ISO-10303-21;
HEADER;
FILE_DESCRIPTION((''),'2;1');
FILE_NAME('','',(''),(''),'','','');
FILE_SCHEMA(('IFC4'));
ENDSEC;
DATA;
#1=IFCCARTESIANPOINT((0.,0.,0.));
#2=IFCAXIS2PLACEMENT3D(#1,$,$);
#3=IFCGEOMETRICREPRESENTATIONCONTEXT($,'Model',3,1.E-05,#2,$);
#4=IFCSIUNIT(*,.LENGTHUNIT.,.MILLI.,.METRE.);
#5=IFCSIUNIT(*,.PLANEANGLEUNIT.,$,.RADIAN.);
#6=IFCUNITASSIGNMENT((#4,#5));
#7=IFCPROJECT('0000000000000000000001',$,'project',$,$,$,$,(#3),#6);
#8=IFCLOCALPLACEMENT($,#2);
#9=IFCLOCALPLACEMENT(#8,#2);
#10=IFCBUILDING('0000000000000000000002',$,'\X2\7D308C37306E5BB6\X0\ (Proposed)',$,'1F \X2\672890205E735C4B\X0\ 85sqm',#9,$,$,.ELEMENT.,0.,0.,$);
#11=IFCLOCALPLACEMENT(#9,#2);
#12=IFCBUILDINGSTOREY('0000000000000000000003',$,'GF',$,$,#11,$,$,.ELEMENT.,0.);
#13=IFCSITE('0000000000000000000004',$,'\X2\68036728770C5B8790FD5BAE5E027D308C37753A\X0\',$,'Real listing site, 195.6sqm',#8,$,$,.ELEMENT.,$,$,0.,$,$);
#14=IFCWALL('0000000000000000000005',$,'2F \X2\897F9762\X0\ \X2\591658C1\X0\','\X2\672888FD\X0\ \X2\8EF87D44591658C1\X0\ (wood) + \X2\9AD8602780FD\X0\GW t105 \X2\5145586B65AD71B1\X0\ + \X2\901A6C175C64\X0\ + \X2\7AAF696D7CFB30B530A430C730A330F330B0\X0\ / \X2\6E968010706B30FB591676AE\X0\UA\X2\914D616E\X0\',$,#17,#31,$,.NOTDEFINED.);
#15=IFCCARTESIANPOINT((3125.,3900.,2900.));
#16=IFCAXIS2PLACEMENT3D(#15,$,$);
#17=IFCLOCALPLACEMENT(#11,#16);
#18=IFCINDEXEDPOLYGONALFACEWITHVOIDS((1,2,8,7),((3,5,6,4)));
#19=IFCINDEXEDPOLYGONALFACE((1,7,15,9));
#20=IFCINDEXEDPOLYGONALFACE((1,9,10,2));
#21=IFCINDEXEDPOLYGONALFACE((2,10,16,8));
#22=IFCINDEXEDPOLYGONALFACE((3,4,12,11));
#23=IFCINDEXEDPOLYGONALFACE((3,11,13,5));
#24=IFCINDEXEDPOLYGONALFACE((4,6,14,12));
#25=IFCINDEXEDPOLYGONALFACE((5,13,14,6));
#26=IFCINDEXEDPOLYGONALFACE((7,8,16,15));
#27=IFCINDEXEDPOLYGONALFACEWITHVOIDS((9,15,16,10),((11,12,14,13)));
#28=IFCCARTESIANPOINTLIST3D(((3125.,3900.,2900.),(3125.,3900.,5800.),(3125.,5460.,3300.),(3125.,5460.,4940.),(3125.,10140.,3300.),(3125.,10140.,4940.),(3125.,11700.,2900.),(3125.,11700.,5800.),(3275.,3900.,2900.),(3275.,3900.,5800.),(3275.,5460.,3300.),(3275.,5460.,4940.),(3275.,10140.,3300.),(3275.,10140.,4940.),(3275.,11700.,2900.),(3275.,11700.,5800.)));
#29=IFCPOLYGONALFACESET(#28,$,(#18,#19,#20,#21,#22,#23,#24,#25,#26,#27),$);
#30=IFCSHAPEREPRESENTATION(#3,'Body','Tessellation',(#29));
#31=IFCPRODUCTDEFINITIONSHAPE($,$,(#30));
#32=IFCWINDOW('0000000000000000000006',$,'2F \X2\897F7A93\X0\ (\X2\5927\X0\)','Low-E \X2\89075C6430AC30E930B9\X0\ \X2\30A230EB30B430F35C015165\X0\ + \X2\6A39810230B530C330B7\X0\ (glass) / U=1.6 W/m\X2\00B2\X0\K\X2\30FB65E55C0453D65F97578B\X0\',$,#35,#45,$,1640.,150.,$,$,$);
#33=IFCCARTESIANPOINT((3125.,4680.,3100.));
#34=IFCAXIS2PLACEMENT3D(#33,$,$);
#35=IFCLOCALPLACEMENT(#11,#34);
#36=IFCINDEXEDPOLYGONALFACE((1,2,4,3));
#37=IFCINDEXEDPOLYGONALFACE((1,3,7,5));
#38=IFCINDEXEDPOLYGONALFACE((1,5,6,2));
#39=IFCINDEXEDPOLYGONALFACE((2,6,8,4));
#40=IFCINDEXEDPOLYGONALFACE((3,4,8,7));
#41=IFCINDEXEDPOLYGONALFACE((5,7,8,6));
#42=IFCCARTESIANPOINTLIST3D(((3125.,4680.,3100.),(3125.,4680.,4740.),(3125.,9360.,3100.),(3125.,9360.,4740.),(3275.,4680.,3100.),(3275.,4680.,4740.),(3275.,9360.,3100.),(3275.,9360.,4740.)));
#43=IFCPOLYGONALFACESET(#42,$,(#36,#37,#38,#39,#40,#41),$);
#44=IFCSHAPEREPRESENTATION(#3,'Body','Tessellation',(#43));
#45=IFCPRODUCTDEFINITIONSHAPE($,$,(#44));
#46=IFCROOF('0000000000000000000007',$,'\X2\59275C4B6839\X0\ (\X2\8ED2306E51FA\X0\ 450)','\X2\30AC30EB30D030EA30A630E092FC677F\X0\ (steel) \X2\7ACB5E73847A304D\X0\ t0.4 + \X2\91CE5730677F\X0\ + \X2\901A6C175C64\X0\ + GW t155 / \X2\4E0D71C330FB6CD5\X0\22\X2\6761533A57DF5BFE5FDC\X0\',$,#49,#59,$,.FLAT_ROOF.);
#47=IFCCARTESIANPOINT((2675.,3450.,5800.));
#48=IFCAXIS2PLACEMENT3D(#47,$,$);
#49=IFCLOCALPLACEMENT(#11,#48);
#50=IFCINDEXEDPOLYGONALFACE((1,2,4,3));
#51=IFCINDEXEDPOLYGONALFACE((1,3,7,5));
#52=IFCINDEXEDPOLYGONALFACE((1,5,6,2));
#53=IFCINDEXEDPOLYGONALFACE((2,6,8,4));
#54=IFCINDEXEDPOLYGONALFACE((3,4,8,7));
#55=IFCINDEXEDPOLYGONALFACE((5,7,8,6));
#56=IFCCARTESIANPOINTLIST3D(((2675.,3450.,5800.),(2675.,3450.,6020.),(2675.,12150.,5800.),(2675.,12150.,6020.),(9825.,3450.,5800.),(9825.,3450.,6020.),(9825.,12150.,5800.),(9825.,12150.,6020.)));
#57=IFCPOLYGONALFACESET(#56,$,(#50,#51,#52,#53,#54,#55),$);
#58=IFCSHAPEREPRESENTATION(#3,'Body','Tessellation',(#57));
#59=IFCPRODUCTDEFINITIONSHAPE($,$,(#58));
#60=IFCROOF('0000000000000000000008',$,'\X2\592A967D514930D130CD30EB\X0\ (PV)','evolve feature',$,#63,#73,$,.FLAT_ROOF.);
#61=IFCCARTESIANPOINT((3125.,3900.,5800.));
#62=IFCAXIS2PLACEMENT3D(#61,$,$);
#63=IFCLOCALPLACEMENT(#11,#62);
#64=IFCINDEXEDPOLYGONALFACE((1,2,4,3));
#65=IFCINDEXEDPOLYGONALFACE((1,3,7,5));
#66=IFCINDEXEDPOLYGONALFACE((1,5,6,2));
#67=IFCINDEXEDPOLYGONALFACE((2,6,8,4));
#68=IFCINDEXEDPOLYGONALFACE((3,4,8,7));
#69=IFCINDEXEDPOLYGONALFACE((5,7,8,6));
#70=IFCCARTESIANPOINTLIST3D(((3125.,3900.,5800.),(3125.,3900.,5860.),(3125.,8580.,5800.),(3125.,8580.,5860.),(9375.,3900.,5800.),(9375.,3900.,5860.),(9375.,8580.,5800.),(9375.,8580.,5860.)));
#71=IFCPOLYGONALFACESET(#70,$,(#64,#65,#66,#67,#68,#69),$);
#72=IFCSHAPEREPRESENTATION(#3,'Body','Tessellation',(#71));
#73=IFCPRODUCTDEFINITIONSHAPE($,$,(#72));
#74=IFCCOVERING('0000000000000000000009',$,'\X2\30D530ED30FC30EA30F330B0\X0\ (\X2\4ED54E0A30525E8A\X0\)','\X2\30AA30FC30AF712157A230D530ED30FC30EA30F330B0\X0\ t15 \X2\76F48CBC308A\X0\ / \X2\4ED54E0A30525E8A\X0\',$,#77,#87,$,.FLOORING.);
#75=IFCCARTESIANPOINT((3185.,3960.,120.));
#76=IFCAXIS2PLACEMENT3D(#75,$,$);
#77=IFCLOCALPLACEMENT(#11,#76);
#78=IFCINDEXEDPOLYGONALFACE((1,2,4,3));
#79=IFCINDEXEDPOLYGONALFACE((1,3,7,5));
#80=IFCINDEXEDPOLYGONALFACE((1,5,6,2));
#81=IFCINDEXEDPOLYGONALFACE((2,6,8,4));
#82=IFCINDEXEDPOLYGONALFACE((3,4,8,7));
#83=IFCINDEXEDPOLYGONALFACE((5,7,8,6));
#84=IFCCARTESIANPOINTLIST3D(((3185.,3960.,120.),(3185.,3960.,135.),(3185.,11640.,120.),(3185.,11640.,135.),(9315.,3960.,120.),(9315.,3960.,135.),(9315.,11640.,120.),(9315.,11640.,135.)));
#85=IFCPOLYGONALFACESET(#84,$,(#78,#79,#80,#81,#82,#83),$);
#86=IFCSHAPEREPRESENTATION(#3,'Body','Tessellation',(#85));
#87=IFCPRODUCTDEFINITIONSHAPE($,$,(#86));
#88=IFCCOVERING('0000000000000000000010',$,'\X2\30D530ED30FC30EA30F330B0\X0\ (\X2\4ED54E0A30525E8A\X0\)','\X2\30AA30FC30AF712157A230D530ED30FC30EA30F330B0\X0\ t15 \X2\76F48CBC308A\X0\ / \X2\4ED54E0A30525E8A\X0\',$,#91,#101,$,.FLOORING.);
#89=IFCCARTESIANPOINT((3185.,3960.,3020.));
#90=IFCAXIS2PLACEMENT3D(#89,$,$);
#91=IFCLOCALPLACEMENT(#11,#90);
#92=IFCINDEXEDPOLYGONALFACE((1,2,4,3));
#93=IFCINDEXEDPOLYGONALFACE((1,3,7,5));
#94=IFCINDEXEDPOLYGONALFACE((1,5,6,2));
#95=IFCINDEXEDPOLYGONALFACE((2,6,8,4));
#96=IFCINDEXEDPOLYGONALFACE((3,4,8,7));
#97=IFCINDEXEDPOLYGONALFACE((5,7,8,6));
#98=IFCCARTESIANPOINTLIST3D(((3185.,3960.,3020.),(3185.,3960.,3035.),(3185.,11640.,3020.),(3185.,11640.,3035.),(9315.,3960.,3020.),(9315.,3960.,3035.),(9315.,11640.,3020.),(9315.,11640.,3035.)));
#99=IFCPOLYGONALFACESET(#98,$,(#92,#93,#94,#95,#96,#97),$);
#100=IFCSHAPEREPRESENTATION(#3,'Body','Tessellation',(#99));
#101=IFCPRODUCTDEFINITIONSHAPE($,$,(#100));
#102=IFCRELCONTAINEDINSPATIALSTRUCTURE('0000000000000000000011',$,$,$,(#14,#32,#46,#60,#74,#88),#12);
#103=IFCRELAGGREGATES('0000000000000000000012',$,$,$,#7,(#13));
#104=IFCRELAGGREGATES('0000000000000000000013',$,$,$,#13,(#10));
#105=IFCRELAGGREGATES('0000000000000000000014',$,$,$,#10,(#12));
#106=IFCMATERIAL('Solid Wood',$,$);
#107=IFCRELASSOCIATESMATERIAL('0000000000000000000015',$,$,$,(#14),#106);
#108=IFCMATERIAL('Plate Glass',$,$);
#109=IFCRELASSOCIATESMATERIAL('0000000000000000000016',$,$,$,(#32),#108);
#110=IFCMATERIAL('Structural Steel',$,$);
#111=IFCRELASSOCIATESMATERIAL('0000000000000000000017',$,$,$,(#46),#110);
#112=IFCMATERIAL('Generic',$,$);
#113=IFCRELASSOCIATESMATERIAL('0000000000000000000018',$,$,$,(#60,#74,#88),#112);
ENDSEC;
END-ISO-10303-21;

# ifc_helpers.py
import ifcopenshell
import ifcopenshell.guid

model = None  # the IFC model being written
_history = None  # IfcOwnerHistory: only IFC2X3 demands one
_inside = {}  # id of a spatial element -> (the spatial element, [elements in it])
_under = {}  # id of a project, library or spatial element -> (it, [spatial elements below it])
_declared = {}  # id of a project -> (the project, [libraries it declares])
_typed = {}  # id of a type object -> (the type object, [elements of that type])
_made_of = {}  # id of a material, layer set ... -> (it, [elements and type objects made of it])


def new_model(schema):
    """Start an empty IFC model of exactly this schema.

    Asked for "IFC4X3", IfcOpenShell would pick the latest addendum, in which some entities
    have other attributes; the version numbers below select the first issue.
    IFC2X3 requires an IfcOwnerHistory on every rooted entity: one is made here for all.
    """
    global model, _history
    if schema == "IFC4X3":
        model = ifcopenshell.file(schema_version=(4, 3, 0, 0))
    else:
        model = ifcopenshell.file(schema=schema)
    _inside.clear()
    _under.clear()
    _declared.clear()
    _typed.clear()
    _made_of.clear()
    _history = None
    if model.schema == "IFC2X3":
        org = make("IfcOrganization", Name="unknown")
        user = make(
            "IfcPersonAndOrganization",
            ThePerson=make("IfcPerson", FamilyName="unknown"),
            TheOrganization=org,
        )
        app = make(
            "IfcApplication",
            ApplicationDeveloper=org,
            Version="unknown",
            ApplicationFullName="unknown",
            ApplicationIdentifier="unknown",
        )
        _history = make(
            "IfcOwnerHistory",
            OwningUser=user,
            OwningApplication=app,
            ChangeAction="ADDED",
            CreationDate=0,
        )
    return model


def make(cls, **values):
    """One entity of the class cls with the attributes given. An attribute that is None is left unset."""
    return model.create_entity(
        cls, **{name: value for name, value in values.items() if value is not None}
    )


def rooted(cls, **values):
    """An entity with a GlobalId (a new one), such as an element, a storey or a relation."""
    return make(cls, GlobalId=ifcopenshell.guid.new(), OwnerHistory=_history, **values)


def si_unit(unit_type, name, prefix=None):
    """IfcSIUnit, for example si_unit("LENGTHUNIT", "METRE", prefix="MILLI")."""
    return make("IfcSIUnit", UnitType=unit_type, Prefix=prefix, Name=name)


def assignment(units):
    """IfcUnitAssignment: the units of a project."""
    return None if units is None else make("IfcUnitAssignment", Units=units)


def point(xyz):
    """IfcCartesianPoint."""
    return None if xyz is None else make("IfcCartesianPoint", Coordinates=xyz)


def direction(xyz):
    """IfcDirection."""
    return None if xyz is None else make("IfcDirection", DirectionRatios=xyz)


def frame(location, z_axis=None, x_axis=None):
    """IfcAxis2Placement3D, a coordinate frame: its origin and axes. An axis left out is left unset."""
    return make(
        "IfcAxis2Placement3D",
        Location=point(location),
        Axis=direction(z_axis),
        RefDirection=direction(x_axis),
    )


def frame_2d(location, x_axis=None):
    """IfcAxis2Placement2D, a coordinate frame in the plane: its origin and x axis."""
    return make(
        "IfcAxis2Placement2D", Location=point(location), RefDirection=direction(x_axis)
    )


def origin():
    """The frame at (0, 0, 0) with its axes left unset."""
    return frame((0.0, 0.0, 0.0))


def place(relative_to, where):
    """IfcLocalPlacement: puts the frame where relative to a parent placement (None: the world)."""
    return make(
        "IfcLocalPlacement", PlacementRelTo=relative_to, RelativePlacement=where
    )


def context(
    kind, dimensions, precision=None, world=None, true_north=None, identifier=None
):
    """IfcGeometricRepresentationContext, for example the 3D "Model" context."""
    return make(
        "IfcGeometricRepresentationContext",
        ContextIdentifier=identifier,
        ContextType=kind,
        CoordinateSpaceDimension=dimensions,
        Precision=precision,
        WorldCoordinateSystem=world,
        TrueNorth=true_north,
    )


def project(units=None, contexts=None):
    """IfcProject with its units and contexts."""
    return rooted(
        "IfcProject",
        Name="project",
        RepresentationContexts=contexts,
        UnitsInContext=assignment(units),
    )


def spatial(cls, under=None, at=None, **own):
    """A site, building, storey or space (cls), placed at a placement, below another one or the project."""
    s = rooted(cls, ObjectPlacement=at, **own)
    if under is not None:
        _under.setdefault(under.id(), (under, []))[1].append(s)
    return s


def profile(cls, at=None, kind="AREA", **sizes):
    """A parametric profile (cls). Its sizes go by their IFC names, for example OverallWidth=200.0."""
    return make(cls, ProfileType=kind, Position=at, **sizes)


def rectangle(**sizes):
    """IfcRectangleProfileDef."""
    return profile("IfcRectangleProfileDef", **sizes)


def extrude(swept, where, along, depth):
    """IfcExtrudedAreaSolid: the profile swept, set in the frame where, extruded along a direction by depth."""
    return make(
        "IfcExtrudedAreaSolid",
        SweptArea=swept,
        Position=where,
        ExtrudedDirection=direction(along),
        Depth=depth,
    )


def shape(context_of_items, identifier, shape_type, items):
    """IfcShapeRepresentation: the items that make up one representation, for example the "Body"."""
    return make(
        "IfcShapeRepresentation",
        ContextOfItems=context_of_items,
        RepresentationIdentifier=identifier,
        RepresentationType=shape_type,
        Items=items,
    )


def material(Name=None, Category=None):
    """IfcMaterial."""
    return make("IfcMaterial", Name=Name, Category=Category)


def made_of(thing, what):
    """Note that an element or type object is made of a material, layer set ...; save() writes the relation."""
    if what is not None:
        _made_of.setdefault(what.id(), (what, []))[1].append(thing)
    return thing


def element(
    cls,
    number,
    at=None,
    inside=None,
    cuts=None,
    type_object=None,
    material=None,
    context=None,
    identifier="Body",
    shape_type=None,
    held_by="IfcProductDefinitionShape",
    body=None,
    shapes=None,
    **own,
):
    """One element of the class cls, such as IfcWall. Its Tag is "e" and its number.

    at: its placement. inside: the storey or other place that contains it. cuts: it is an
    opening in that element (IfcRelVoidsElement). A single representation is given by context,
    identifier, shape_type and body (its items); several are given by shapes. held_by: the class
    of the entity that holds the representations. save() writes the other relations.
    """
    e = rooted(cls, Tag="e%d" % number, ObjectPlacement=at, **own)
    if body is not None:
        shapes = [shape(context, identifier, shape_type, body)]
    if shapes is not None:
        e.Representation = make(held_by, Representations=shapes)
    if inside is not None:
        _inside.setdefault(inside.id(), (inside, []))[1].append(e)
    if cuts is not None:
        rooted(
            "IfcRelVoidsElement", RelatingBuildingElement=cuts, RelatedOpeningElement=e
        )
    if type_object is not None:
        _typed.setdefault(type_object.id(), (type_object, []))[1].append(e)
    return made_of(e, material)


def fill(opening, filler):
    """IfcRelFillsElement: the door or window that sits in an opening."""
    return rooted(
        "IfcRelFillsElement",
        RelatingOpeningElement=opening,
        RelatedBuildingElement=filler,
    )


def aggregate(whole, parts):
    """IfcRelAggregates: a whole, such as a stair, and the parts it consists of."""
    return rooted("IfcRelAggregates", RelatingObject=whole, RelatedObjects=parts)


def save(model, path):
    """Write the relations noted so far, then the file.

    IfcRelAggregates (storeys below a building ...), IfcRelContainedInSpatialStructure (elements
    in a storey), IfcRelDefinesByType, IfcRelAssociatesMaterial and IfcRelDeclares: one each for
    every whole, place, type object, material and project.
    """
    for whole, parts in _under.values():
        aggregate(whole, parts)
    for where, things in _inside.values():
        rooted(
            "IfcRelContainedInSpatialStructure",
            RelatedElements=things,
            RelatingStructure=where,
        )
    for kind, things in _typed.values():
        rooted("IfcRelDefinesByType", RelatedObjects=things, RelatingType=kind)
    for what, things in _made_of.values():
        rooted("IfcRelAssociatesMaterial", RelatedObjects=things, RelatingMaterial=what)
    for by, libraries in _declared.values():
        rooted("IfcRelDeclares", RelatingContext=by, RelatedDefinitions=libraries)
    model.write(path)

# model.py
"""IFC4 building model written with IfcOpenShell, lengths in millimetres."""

from ifc_helpers import new_model, si_unit, frame, frame_2d, origin, place, context, project, spatial, rectangle, extrude, material, element, fill, save


model = new_model("IFC4")

# Units and contexts
model_context = context("Model", 3, precision=1e-05, world=origin())
ifc_project = project(units=[si_unit("LENGTHUNIT", "METRE", prefix="MILLI"), si_unit("PLANEANGLEUNIT", "RADIAN")], contexts=[model_context])

# Site, building, storey
site_placement = place(None, origin())
site = spatial("IfcSite", under=ifc_project, at=site_placement, Name="栃木県宇都宮市細谷町", ObjectType="Real listing site, 195.6sqm", CompositionType="ELEMENT", RefElevation=0.0)
building_placement = place(site_placement, origin())
building = spatial("IfcBuilding", under=site, at=building_placement, Name="細谷の家 (Proposed)", ObjectType="1F 木造平屋 85sqm", CompositionType="ELEMENT", ElevationOfRefHeight=0.0, ElevationOfTerrain=0.0)
storey_placement = place(building_placement, origin())
storey = spatial("IfcBuildingStorey", under=building, at=storey_placement, Name="GF", CompositionType="ELEMENT", Elevation=0.0)

# Shared definitions
ifc_material_1 = material(Name="Solid Wood")
ifc_material_2 = material(Name="Generic")

# Shared definitions
ifc_material_3 = material(Name="Plate Glass")

# Wall, opening, window
wall_1_placement = place(storey_placement, frame((3125.0, 3900.0, 2900.0)))
wall_1 = element("IfcWall", 1, at=wall_1_placement, inside=storey, material=ifc_material_1, Name="2F 西面 外壁", Description="木製 軸組外壁 (wood) + 高性能GW t105 充填断熱 + 通気層 + 窯業系サイディング / 準耐火・外皮UA配慮", PredefinedType="NOTDEFINED", context=model_context, shape_type="SweptSolid", body=[
    extrude(rectangle(XDim=150.0, YDim=7800.0, at=frame_2d((75.0, 3900.0))), frame((3125.0, 3900.0, 2900.0)), (0.0, 0.0, 1.0), 2900.0),
])
opening_1_placement = place(storey_placement, frame((3125.0, 4680.0, 3100.0)))
opening_1 = element("IfcOpeningElement", 2, at=opening_1_placement, cuts=wall_1, PredefinedType="NOTDEFINED", context=model_context, shape_type="SweptSolid", body=[
    extrude(rectangle(XDim=150.0, YDim=4680.0, at=frame_2d((75.0, 2340.0))), frame((3125.0, 4680.0, 3100.0)), (0.0, 0.0, 1.0), 1640.0),
])
window_1_placement = place(storey_placement, frame((3125.0, 4680.0, 3100.0)))
window_1 = element("IfcWindow", 3, at=window_1_placement, inside=storey, material=ifc_material_3, Name="2F 西窓 (大)", Description="Low-E 複層ガラス アルゴン封入 + 樹脂サッシ (glass) / U=1.6 W/m²K・日射取得型", OverallHeight=1640.0, OverallWidth=150.0, context=model_context, shape_type="SweptSolid", body=[
    extrude(rectangle(XDim=150.0, YDim=4680.0, at=frame_2d((75.0, 2340.0))), frame((3125.0, 4680.0, 3100.0)), (0.0, 0.0, 1.0), 1640.0),
])
fill(opening_1, window_1)

# Roofs
ifc_material_4 = material(Name="Structural Steel")
roof_1_placement = place(storey_placement, frame((2675.0, 3450.0, 5800.0)))
element("IfcRoof", 4, at=roof_1_placement, inside=storey, material=ifc_material_4, Name="大屋根 (軒の出 450)", Description="ガルバリウム鋼板 (steel) 立平葺き t0.4 + 野地板 + 通気層 + GW t155 / 不燃・法22条区域対応", PredefinedType="FLAT_ROOF", context=model_context, shape_type="SweptSolid", body=[
    extrude(rectangle(XDim=7150.0, YDim=8700.0, at=frame_2d((3575.0, 4350.0))), frame((2675.0, 3450.0, 5800.0)), (0.0, 0.0, 1.0), 220.0),
])
roof_2_placement = place(storey_placement, frame((3125.0, 3900.0, 5800.0)))
element("IfcRoof", 5, at=roof_2_placement, inside=storey, material=ifc_material_2, Name="太陽光パネル (PV)", Description="evolve feature", PredefinedType="FLAT_ROOF", context=model_context, shape_type="SweptSolid", body=[
    extrude(rectangle(XDim=6250.0, YDim=4680.0, at=frame_2d((3125.0, 2340.0))), frame((3125.0, 3900.0, 5800.0)), (0.0, 0.0, 1.0), 60.0),
])

# Coverings
covering_1_placement = place(storey_placement, frame((3185.0, 3960.0, 120.0)))
element("IfcCovering", 6, at=covering_1_placement, inside=storey, material=ifc_material_2, Name="フローリング (仕上げ床)", Description="オーク無垢フローリング t15 直貼り / 仕上げ床", PredefinedType="FLOORING", context=model_context, shape_type="SweptSolid", body=[
    extrude(rectangle(XDim=6130.0, YDim=7680.0, at=frame_2d((3065.0, 3840.0))), frame((3185.0, 3960.0, 120.0)), (0.0, 0.0, 1.0), 15.0),
])
covering_2_placement = place(storey_placement, frame((3185.0, 3960.0, 3020.0)))
element("IfcCovering", 7, at=covering_2_placement, inside=storey, material=ifc_material_2, Name="フローリング (仕上げ床)", Description="オーク無垢フローリング t15 直貼り / 仕上げ床", PredefinedType="FLOORING", context=model_context, shape_type="SweptSolid", body=[
    extrude(rectangle(XDim=6130.0, YDim=7680.0, at=frame_2d((3065.0, 3840.0))), frame((3185.0, 3960.0, 3020.0)), (0.0, 0.0, 1.0), 15.0),
])

save(model, "model.ifc")
